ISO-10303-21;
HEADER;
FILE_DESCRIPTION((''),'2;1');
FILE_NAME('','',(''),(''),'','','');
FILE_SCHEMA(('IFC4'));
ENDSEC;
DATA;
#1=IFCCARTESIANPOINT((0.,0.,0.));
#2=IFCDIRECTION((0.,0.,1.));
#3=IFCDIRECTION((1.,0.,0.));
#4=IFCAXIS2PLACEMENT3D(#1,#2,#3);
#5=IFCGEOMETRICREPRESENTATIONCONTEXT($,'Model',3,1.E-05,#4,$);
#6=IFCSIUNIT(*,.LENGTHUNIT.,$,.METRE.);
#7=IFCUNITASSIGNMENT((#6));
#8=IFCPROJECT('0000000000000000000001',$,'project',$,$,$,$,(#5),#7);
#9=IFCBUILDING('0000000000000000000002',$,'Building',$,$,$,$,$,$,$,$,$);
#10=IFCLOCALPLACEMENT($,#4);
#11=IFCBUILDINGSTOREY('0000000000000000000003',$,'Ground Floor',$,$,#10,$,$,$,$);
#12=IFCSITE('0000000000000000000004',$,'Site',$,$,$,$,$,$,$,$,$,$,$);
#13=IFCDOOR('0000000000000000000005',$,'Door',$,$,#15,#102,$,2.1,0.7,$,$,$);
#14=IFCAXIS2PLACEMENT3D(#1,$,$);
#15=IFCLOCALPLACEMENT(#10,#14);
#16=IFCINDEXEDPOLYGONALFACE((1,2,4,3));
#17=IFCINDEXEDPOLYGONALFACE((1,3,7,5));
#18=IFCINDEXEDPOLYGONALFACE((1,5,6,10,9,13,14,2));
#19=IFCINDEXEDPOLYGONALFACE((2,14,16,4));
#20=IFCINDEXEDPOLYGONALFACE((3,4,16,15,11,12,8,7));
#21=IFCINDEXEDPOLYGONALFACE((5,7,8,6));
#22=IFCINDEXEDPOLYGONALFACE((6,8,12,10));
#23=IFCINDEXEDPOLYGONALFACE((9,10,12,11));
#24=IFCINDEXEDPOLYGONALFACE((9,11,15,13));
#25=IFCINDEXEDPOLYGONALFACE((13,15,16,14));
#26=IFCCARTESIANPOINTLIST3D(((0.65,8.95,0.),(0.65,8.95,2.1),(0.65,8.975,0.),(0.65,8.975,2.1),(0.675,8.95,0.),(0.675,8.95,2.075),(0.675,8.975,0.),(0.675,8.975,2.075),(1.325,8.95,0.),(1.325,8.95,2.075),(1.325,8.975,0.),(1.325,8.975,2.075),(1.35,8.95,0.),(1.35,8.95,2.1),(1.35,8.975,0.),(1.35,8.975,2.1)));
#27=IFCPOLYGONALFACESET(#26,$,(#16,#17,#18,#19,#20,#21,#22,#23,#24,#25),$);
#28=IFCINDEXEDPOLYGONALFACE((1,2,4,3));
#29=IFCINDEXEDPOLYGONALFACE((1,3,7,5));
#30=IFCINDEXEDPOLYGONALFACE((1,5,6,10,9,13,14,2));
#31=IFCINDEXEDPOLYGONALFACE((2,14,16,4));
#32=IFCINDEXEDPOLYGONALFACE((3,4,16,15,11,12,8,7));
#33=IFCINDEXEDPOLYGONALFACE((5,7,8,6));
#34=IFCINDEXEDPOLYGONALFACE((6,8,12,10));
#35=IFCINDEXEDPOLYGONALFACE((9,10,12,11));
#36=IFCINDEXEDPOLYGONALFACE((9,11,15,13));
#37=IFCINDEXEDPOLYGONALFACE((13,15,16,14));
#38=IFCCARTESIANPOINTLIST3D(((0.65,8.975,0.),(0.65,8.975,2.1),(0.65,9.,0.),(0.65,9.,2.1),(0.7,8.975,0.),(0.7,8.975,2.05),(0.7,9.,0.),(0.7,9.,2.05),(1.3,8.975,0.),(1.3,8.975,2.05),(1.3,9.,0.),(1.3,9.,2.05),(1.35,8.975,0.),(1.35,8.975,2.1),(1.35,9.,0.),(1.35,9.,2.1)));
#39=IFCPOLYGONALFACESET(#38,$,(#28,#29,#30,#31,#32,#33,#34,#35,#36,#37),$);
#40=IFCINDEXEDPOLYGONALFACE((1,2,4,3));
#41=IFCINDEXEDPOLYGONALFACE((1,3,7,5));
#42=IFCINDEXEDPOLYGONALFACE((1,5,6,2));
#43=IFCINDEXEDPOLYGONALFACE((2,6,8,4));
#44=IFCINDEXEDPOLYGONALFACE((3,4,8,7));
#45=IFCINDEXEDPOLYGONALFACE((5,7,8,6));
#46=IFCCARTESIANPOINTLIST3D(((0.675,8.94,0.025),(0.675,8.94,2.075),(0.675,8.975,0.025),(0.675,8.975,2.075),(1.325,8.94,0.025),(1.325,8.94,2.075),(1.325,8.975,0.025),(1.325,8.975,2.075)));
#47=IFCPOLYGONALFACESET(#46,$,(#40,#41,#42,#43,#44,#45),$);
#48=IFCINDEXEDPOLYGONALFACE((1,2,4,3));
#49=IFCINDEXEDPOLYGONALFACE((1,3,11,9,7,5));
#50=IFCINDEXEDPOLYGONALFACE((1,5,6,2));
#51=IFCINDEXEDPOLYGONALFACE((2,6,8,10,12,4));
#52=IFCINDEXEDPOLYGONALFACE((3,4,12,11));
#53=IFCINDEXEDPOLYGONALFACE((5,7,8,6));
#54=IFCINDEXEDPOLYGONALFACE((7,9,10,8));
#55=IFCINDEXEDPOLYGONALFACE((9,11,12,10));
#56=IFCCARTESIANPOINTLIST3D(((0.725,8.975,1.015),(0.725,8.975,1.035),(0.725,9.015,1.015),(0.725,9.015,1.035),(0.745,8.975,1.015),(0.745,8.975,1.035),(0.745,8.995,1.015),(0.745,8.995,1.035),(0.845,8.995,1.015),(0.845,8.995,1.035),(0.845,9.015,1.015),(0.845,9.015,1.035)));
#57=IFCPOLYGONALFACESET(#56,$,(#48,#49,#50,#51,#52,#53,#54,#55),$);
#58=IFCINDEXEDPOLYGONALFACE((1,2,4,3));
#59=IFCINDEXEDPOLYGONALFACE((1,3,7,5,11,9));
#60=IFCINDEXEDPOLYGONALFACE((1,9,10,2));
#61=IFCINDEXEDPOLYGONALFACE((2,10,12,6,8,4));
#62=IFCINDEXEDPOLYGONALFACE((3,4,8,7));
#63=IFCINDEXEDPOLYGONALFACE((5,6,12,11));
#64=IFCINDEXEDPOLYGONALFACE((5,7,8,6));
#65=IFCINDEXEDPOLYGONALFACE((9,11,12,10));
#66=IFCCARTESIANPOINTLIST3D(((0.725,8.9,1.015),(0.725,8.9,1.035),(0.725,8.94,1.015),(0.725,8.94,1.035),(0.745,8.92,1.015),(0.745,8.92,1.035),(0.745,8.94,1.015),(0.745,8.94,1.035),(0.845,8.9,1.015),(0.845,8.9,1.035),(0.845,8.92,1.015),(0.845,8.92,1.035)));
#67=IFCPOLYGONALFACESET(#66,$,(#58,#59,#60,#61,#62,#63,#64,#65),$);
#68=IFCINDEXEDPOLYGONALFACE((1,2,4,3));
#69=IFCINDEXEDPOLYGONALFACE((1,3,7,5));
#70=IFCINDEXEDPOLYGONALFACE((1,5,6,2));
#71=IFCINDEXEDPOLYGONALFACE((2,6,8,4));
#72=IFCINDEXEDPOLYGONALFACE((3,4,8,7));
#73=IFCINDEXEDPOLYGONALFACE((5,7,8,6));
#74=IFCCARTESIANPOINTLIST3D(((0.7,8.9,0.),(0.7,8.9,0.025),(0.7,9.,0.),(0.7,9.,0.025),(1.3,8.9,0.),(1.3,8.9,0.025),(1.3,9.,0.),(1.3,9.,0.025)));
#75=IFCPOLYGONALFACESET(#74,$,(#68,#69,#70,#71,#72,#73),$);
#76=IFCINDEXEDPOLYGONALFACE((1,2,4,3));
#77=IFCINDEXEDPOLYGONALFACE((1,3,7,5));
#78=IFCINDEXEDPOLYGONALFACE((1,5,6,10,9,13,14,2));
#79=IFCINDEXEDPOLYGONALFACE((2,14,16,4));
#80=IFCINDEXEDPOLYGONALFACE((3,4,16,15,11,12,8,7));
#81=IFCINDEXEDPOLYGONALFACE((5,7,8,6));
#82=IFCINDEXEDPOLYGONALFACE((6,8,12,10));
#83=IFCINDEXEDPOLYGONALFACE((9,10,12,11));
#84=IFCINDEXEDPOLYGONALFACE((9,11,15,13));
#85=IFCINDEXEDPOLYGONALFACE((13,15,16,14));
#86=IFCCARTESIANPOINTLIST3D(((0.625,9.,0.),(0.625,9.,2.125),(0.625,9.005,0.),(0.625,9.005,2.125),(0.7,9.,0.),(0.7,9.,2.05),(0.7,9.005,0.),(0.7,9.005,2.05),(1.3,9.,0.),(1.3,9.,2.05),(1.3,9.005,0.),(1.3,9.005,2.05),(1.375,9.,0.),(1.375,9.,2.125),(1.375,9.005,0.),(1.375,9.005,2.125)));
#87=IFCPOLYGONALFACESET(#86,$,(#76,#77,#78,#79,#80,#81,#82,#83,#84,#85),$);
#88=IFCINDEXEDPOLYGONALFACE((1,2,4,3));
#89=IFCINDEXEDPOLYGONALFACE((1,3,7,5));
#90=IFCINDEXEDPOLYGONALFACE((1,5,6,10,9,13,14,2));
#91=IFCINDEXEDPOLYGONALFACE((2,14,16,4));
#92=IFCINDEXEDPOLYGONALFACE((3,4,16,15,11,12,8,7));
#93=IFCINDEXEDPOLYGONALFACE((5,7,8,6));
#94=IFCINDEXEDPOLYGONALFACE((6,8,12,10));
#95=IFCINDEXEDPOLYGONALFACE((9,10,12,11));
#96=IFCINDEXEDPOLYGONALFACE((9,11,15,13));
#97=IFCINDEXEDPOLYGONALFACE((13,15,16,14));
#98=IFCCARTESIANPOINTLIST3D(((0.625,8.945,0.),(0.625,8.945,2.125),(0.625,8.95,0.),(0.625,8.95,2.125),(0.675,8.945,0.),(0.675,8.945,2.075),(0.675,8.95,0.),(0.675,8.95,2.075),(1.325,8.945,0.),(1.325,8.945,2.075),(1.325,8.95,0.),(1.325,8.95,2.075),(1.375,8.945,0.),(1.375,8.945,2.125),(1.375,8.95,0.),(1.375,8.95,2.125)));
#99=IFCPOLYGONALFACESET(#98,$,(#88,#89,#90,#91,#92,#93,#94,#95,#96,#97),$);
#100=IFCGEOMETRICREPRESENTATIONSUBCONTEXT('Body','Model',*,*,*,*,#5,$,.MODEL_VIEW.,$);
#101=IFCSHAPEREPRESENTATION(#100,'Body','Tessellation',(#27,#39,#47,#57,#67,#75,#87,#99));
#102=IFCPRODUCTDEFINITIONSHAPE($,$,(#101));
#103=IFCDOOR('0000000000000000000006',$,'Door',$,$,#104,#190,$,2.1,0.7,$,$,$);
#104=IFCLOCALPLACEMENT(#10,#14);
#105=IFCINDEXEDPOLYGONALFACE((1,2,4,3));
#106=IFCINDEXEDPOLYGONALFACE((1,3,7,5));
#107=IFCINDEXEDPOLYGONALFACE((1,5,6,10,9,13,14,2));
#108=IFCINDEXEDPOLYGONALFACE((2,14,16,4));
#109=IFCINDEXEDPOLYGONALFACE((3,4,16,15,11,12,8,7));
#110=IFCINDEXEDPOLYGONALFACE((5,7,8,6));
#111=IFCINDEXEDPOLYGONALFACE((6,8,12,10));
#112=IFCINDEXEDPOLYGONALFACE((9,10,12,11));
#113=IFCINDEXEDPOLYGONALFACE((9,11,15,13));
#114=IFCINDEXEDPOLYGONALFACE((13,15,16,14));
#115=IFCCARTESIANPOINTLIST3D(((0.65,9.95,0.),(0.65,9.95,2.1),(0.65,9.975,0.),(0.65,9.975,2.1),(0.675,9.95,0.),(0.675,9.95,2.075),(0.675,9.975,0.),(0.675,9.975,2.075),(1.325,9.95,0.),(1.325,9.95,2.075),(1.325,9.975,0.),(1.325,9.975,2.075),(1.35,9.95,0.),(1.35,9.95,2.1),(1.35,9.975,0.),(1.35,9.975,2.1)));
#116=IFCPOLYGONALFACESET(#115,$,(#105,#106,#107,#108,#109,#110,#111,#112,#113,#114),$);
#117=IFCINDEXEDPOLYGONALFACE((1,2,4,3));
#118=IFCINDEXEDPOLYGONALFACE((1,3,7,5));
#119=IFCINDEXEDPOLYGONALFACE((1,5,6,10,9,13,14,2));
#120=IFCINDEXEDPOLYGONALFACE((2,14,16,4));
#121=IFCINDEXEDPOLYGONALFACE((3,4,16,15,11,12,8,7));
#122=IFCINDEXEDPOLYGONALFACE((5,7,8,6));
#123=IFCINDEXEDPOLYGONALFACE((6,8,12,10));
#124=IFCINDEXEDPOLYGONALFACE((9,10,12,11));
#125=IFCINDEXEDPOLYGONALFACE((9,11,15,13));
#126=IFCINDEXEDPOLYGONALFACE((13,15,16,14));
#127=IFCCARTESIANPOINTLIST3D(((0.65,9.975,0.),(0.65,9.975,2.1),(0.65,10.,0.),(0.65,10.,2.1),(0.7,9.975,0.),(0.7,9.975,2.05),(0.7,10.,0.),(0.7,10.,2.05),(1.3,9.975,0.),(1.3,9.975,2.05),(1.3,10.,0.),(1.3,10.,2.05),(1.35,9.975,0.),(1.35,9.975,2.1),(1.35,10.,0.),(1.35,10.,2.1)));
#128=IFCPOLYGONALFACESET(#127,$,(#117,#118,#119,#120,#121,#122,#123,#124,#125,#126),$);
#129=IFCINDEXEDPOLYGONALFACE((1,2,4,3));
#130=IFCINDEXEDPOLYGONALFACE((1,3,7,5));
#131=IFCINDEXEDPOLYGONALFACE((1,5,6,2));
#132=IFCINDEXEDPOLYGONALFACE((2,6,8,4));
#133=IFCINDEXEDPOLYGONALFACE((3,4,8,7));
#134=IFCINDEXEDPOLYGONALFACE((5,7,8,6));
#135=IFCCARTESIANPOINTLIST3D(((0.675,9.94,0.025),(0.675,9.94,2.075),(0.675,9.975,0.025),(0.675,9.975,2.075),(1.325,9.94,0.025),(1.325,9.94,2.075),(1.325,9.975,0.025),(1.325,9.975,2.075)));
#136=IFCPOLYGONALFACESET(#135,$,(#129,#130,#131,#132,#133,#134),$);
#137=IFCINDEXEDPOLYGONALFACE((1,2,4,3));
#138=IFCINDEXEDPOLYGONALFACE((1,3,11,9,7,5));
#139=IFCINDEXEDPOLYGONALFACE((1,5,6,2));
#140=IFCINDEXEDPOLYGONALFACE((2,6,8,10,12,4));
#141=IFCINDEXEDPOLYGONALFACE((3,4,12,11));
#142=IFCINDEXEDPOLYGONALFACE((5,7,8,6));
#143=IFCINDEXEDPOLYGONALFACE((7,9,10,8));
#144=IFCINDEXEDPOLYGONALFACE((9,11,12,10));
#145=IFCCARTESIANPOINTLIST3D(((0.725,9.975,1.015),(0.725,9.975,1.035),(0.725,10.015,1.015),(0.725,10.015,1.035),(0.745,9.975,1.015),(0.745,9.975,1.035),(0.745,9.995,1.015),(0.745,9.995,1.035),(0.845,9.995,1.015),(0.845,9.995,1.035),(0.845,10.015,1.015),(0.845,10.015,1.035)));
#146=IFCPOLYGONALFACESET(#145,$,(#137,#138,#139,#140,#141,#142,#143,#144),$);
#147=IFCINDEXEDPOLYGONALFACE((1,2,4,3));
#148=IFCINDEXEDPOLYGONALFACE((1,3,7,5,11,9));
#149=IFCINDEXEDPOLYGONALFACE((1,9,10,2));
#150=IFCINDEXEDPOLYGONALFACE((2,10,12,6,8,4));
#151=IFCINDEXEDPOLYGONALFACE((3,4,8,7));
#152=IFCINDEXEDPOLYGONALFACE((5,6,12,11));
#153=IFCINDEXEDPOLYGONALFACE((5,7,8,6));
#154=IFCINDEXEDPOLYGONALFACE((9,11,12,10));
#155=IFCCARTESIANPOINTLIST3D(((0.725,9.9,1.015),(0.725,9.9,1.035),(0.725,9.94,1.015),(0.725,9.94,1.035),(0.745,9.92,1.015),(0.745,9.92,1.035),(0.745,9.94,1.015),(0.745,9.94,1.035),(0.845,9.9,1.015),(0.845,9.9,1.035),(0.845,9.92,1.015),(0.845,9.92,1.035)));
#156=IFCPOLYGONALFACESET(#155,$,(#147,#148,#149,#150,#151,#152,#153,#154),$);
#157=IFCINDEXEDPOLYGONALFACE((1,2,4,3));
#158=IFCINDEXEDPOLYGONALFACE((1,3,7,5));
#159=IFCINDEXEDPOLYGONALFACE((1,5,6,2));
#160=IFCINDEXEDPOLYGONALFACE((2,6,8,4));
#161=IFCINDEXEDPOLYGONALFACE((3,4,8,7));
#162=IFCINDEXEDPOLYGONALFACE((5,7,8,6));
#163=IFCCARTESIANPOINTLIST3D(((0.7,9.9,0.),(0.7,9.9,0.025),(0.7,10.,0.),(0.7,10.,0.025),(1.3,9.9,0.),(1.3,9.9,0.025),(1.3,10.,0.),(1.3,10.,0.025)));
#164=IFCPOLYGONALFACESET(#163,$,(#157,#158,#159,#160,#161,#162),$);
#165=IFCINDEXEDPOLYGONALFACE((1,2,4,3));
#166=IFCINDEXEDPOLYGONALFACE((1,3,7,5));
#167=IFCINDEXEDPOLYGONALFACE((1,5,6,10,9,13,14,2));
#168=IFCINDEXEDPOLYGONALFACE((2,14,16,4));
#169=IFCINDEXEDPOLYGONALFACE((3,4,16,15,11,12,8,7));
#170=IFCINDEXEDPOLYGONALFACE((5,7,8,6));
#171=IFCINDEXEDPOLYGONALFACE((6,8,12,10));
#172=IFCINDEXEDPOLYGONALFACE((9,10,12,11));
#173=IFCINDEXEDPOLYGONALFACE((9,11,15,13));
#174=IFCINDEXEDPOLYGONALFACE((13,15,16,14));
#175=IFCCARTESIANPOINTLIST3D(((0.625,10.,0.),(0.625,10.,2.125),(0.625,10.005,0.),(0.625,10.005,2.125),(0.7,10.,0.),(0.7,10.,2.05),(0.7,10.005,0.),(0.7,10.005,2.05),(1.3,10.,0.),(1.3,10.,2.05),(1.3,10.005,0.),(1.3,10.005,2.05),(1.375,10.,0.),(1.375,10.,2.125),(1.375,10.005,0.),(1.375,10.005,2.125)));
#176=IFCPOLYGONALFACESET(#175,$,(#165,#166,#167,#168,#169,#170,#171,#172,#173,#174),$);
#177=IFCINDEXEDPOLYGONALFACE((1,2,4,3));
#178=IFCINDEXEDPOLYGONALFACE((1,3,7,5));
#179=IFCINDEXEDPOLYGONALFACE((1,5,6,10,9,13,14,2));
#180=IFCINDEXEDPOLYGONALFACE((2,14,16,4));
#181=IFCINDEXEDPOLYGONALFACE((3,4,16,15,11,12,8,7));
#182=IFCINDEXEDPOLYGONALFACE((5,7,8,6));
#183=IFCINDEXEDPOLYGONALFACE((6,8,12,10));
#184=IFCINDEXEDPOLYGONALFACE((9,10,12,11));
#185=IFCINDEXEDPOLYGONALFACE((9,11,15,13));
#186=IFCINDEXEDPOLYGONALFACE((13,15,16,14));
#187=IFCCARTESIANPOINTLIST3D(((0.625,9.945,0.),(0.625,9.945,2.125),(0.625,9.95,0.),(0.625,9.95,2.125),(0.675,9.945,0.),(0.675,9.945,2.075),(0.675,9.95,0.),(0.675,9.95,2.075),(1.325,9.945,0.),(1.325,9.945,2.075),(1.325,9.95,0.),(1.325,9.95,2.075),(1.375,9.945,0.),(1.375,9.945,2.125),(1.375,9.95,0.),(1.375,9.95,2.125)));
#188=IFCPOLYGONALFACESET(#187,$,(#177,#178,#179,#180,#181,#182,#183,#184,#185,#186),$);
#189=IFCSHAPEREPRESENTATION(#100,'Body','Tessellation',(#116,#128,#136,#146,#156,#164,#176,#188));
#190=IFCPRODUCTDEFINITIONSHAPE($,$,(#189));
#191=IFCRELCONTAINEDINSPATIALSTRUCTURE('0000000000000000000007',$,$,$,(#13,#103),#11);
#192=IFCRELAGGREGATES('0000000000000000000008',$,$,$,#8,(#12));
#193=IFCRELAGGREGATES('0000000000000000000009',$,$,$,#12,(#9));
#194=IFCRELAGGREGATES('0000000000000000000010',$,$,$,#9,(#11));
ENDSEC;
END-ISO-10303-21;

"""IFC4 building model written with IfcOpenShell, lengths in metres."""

from ifc_helpers import new_model, si_unit, frame, origin_with_axes, place, context, subcontext, project, spatial, line, indexed_curve, outline, extrude, element, save


model = new_model("IFC4")

# Units and contexts
model_context = context("Model", 3, precision=1e-05, world=origin_with_axes())
body_context = subcontext(model_context, "Body", "Model", "MODEL_VIEW")
ifc_project = project(units=[si_unit("LENGTHUNIT", "METRE")], contexts=[model_context])

# Site, building, storey
site = spatial("IfcSite", under=ifc_project, Name="Site")
building = spatial("IfcBuilding", under=site, Name="Building")
storey_placement = place(None, origin_with_axes())
storey = spatial("IfcBuildingStorey", under=building, at=storey_placement, Name="Ground Floor")

# Doors
door_1_placement = place(storey_placement, frame((1.35, 9.0, 0.0), z_axis=(0.0, 0.0, 1.0), x_axis=(-1.0, 0.0, 0.0)))
element("IfcDoor", 1, at=door_1_placement, inside=storey, Name="Door", OverallHeight=2.1, OverallWidth=0.7, context=body_context, shape_type="SweptSolid", body=[
    extrude(outline(indexed_curve([(0.0, 0.0), (0.0, 2.1), (0.7, 2.1), (0.7, 0.0), (0.675, 0.0), (0.675, 2.075), (0.025, 2.075), (0.025, 0.0)], segments=[line(1, 2, 3, 4, 5, 6, 7, 8, 1)])), frame((0.0, 0.025, 0.0), z_axis=(0.0, -1.0, 0.0), x_axis=(1.0, 0.0, 0.0)), (0.0, 0.0, -1.0), 0.025),
    extrude(outline(indexed_curve([(0.0, 0.0), (0.0, 2.1), (0.7, 2.1), (0.7, 0.0), (0.65, 0.0), (0.65, 2.05), (0.05, 2.05), (0.05, 0.0)], segments=[line(1, 2, 3, 4, 5, 6, 7, 8, 1)])), frame((0.0, 0.0, 0.0), z_axis=(0.0, -1.0, 0.0), x_axis=(1.0, 0.0, 0.0)), (0.0, 0.0, -1.0), 0.025),
    extrude(outline(indexed_curve([(0.0, 0.0), (0.65, 0.0), (0.65, 0.035), (0.0, 0.035)], segments=[line(1, 2, 3, 4, 1)])), frame((0.025, 0.025, 0.025), z_axis=(0.0, 0.0, 1.0), x_axis=(1.0, 0.0, 0.0)), (0.0, 0.0, 1.0), 2.05),
    extrude(outline(indexed_curve([(0.0, 0.0), (0.0, -0.04), (-0.12, -0.04), (-0.12, -0.02), (-0.02, -0.02), (-0.02, 0.0)], segments=[line(1, 2, 3, 4, 5, 6, 1)])), frame((0.625, 0.025, 1.015), z_axis=(0.0, 0.0, 1.0), x_axis=(1.0, 0.0, 0.0)), (0.0, 0.0, 1.0), 0.02),
    extrude(outline(indexed_curve([(0.0, 0.0), (0.0, 0.04), (-0.12, 0.04), (-0.12, 0.02), (-0.02, 0.02), (-0.02, 0.0)], segments=[line(1, 2, 3, 4, 5, 6, 1)])), frame((0.625, 0.06, 1.015), z_axis=(0.0, 0.0, 1.0), x_axis=(1.0, 0.0, 0.0)), (0.0, 0.0, 1.0), 0.02),
    extrude(outline(indexed_curve([(0.0, 0.0), (0.6, 0.0), (0.6, 0.1), (0.0, 0.1)], segments=[line(1, 2, 3, 4, 1)])), frame((0.05, 0.0, 0.0), z_axis=(0.0, 0.0, 1.0), x_axis=(1.0, 0.0, 0.0)), (0.0, 0.0, 1.0), 0.025),
    extrude(outline(indexed_curve([(0.0, 0.0), (0.0, 2.125), (0.75, 2.125), (0.75, 0.0), (0.675, 0.0), (0.675, 2.05), (0.075, 2.05), (0.075, 0.0)], segments=[line(1, 2, 3, 4, 5, 6, 7, 8, 1)])), frame((-0.025, -0.005, 0.0), z_axis=(0.0, -1.0, 0.0), x_axis=(1.0, 0.0, 0.0)), (0.0, 0.0, -1.0), 0.005),
    extrude(outline(indexed_curve([(0.0, 0.0), (0.0, 2.125), (0.75, 2.125), (0.75, 0.0), (0.7, 0.0), (0.7, 2.075), (0.05, 2.075), (0.05, 0.0)], segments=[line(1, 2, 3, 4, 5, 6, 7, 8, 1)])), frame((-0.025, 0.05, 0.0), z_axis=(0.0, -1.0, 0.0), x_axis=(1.0, 0.0, 0.0)), (0.0, 0.0, -1.0), 0.005),
])
door_2_placement = place(storey_placement, frame((1.35, 10.0, 0.0), z_axis=(0.0, 0.0, 1.0), x_axis=(-1.0, 0.0, 0.0)))
element("IfcDoor", 2, at=door_2_placement, inside=storey, Name="Door", OverallHeight=2.1, OverallWidth=0.7, context=body_context, shape_type="SweptSolid", body=[
    extrude(outline(indexed_curve([(0.0, 0.0), (0.0, 2.1), (0.7, 2.1), (0.7, 0.0), (0.675, 0.0), (0.675, 2.075), (0.025, 2.075), (0.025, 0.0)], segments=[line(1, 2, 3, 4, 5, 6, 7, 8, 1)])), frame((0.0, 0.025, 0.0), z_axis=(0.0, -1.0, 0.0), x_axis=(1.0, 0.0, 0.0)), (0.0, 0.0, -1.0), 0.025),
    extrude(outline(indexed_curve([(0.0, 0.0), (0.0, 2.1), (0.7, 2.1), (0.7, 0.0), (0.65, 0.0), (0.65, 2.05), (0.05, 2.05), (0.05, 0.0)], segments=[line(1, 2, 3, 4, 5, 6, 7, 8, 1)])), frame((0.0, 0.0, 0.0), z_axis=(0.0, -1.0, 0.0), x_axis=(1.0, 0.0, 0.0)), (0.0, 0.0, -1.0), 0.025),
    extrude(outline(indexed_curve([(0.0, 0.0), (0.65, 0.0), (0.65, 0.035), (0.0, 0.035)], segments=[line(1, 2, 3, 4, 1)])), frame((0.025, 0.025, 0.025), z_axis=(0.0, 0.0, 1.0), x_axis=(1.0, 0.0, 0.0)), (0.0, 0.0, 1.0), 2.05),
    extrude(outline(indexed_curve([(0.0, 0.0), (0.0, -0.04), (-0.12, -0.04), (-0.12, -0.02), (-0.02, -0.02), (-0.02, 0.0)], segments=[line(1, 2, 3, 4, 5, 6, 1)])), frame((0.625, 0.025, 1.015), z_axis=(0.0, 0.0, 1.0), x_axis=(1.0, 0.0, 0.0)), (0.0, 0.0, 1.0), 0.02),
    extrude(outline(indexed_curve([(0.0, 0.0), (0.0, 0.04), (-0.12, 0.04), (-0.12, 0.02), (-0.02, 0.02), (-0.02, 0.0)], segments=[line(1, 2, 3, 4, 5, 6, 1)])), frame((0.625, 0.06, 1.015), z_axis=(0.0, 0.0, 1.0), x_axis=(1.0, 0.0, 0.0)), (0.0, 0.0, 1.0), 0.02),
    extrude(outline(indexed_curve([(0.0, 0.0), (0.6, 0.0), (0.6, 0.1), (0.0, 0.1)], segments=[line(1, 2, 3, 4, 1)])), frame((0.05, 0.0, 0.0), z_axis=(0.0, 0.0, 1.0), x_axis=(1.0, 0.0, 0.0)), (0.0, 0.0, 1.0), 0.025),
    extrude(outline(indexed_curve([(0.0, 0.0), (0.0, 2.125), (0.75, 2.125), (0.75, 0.0), (0.675, 0.0), (0.675, 2.05), (0.075, 2.05), (0.075, 0.0)], segments=[line(1, 2, 3, 4, 5, 6, 7, 8, 1)])), frame((-0.025, -0.005, 0.0), z_axis=(0.0, -1.0, 0.0), x_axis=(1.0, 0.0, 0.0)), (0.0, 0.0, -1.0), 0.005),
    extrude(outline(indexed_curve([(0.0, 0.0), (0.0, 2.125), (0.75, 2.125), (0.75, 0.0), (0.7, 0.0), (0.7, 2.075), (0.05, 2.075), (0.05, 0.0)], segments=[line(1, 2, 3, 4, 5, 6, 7, 8, 1)])), frame((-0.025, 0.05, 0.0), z_axis=(0.0, -1.0, 0.0), x_axis=(1.0, 0.0, 0.0)), (0.0, 0.0, -1.0), 0.005),
])

save(model, "model.ifc")
